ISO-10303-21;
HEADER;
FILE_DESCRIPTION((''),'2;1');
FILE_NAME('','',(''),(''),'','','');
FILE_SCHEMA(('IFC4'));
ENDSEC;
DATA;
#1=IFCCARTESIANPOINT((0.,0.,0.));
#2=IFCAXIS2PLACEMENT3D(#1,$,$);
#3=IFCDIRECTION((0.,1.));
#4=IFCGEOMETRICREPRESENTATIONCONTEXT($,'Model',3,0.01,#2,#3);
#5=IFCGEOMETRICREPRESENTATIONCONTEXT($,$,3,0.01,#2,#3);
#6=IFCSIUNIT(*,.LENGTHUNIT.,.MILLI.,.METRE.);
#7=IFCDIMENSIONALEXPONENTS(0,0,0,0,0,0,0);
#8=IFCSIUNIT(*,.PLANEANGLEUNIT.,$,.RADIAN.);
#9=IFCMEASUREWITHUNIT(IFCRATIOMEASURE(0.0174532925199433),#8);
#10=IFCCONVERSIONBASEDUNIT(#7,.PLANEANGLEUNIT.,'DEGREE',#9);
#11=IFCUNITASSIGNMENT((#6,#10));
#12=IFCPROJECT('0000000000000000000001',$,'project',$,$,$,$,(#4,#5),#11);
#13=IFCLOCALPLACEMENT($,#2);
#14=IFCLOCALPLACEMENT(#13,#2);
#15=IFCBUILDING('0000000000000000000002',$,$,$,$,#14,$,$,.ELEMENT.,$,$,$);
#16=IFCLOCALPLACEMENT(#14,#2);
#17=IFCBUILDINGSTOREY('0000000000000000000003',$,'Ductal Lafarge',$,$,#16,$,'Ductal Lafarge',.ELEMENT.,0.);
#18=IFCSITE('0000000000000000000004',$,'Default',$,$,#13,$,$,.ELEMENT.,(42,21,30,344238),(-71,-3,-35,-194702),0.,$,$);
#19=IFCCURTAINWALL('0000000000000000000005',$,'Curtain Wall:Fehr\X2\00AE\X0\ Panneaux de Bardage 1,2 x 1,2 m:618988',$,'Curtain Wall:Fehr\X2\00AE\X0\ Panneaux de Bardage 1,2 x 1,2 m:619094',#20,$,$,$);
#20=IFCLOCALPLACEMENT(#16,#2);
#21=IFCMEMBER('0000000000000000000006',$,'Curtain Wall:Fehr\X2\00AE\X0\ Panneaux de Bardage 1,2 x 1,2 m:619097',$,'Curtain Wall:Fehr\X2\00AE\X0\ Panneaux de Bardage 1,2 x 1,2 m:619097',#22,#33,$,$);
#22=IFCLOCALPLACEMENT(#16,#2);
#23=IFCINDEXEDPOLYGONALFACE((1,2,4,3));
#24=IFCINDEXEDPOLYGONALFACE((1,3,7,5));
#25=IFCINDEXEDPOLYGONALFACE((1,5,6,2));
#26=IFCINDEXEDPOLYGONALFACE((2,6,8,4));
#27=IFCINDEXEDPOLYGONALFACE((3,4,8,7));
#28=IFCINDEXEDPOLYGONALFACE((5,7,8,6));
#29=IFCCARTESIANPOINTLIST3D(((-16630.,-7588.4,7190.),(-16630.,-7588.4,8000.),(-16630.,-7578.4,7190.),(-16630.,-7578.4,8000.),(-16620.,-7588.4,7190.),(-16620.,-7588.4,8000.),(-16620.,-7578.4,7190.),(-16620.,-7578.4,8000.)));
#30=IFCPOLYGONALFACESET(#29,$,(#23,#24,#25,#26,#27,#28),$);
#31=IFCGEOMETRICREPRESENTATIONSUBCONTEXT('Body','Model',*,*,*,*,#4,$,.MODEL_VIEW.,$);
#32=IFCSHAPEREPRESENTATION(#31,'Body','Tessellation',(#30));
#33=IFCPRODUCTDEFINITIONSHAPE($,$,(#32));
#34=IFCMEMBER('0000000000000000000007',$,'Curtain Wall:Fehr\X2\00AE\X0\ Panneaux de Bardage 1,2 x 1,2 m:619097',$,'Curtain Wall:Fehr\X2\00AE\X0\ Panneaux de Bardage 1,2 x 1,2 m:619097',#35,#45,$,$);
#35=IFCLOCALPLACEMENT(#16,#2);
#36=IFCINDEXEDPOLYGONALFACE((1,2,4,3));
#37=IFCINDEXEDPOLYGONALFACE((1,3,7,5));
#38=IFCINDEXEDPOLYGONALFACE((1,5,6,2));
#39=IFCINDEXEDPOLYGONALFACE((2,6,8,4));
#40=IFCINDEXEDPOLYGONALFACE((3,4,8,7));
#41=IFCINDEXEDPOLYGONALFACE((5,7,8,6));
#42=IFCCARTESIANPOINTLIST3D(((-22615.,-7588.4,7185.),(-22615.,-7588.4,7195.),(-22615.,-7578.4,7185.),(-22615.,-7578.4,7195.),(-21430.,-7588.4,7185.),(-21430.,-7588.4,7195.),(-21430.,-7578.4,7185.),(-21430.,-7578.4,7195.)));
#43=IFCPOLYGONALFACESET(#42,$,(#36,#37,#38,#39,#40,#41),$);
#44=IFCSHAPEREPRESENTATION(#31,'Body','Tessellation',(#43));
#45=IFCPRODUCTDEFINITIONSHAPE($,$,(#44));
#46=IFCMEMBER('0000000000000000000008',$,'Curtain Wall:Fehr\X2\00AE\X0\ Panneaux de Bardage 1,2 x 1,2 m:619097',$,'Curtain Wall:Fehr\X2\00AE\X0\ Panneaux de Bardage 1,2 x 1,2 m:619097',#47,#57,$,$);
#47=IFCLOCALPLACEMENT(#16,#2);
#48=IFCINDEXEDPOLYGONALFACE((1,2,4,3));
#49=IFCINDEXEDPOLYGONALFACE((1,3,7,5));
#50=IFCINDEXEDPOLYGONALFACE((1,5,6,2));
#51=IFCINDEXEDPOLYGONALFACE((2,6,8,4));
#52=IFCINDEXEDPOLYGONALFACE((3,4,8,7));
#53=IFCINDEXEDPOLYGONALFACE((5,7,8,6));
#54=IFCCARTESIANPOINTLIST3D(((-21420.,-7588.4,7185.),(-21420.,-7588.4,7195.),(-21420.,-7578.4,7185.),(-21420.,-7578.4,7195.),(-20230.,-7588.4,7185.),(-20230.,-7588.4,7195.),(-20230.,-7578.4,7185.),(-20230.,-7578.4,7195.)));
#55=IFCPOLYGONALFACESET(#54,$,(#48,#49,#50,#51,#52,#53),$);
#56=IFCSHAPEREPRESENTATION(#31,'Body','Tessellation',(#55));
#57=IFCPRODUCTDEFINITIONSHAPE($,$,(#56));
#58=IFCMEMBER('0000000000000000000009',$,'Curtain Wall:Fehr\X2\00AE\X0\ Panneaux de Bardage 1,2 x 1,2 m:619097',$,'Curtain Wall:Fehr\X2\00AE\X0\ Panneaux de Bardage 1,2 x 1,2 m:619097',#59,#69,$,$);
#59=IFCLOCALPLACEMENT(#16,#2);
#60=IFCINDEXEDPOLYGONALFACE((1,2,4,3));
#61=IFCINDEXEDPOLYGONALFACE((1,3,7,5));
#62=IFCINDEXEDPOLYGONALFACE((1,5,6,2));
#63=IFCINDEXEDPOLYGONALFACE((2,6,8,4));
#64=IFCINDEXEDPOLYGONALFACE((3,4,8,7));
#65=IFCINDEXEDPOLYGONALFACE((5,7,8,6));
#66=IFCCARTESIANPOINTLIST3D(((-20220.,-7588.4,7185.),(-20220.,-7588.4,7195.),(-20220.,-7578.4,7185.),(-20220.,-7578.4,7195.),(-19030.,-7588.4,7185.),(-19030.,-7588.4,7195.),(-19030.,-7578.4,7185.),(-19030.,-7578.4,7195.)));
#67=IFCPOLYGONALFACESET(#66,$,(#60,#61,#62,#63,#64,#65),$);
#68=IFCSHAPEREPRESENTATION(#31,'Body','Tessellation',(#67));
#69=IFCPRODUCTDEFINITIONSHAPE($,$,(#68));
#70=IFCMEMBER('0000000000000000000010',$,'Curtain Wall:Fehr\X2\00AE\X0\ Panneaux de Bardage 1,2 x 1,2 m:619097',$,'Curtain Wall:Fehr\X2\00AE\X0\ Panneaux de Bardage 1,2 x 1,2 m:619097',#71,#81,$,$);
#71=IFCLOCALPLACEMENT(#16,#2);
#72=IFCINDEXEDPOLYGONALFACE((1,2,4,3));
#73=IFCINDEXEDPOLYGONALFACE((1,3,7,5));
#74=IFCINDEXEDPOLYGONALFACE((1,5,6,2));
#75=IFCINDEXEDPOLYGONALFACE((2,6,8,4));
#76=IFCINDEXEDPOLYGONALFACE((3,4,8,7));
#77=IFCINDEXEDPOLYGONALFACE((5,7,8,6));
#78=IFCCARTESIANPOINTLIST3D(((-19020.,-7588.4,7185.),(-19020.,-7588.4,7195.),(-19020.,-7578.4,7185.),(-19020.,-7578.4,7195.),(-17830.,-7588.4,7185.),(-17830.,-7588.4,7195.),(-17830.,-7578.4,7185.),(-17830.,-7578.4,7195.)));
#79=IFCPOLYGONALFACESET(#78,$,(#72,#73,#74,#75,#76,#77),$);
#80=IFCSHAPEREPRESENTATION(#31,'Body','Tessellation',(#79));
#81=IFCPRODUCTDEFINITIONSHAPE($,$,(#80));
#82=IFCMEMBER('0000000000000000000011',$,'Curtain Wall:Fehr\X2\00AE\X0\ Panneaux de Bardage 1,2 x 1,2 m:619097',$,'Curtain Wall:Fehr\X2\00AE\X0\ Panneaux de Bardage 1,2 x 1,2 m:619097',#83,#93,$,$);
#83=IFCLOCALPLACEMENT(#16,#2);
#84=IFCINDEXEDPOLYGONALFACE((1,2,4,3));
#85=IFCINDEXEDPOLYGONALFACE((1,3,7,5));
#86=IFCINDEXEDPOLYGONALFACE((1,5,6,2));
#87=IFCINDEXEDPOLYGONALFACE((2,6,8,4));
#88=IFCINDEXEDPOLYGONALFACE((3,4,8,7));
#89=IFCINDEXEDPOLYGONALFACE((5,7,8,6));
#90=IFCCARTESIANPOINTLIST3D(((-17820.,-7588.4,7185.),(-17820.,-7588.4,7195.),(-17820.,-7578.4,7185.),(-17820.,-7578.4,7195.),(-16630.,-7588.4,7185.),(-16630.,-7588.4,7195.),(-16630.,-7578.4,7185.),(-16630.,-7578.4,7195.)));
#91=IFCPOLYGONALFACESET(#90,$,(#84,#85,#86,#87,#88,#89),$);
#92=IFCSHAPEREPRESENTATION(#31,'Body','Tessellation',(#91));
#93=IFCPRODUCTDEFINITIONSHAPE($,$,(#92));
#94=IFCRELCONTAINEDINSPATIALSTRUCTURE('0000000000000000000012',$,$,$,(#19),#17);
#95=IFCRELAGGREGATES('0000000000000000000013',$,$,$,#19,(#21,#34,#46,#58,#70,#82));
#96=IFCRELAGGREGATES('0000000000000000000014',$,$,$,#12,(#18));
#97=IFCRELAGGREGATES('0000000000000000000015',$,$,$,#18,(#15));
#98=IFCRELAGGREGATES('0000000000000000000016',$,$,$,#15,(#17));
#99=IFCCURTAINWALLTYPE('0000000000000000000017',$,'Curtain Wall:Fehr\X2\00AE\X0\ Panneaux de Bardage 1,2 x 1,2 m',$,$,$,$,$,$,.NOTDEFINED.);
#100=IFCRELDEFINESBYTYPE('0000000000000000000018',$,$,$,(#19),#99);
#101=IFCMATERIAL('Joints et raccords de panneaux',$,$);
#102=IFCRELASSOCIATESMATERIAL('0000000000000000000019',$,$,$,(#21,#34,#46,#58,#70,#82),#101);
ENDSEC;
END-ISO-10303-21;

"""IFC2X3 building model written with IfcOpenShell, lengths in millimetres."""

from ifc_helpers import new_model, entity, si_unit, converted_unit, direction, frame, frame_2d, origin, origin_2d_with_axis, place, context, subcontext, project, spatial, rectangle, extrude, material, type_object, element, aggregate, save


model = new_model("IFC2X3")

# Units and contexts
model_context = context("Model", 3, precision=0.01, world=origin(), true_north=direction((0.0, 1.0)))
context_of_model = context(None, 3, precision=0.01, world=origin(), true_north=direction((0.0, 1.0)))
body_context = subcontext(model_context, "Body", "Model", "MODEL_VIEW")
ifc_project = project(units=[si_unit("LENGTHUNIT", "METRE", prefix="MILLI"), converted_unit("PLANEANGLEUNIT", "DEGREE", entity("IfcRatioMeasure", 0.0174532925199433), si_unit("PLANEANGLEUNIT", "RADIAN"), dimensions=[0, 0, 0, 0, 0, 0, 0])], contexts=[model_context, context_of_model])

# Site, building, storey
site_placement = place(None, origin())
site = spatial("IfcSite", under=ifc_project, at=site_placement, Name="Default", CompositionType="ELEMENT", RefLatitude=(42, 21, 30, 344238), RefLongitude=(-71, -3, -35, -194702), RefElevation=0.0)
building_placement = place(site_placement, origin())
building = spatial("IfcBuilding", under=site, at=building_placement, CompositionType="ELEMENT")
storey_placement = place(building_placement, origin())
storey = spatial("IfcBuildingStorey", under=building, at=storey_placement, Name="Ductal Lafarge", LongName="Ductal Lafarge", CompositionType="ELEMENT", Elevation=0.0)

# Curtain wall, members
curtain_wall_type = type_object("IfcCurtainWallType", Name="Curtain Wall:Fehr® Panneaux de Bardage 1,2 x 1,2 m", PredefinedType="NOTDEFINED")
curtain_wall_placement = place(storey_placement, origin())
curtain_wall = element("IfcCurtainWall", 1, at=curtain_wall_placement, inside=storey, type_object=curtain_wall_type, Name="Curtain Wall:Fehr® Panneaux de Bardage 1,2 x 1,2 m:618988", ObjectType="Curtain Wall:Fehr® Panneaux de Bardage 1,2 x 1,2 m:619094")
ifc_material = material(Name="Joints et raccords de panneaux")
member_1_placement = place(curtain_wall_placement, frame((-16630.0, -7588.4, 7190.0)))
member_1 = element("IfcMember", 2, at=member_1_placement, material=ifc_material, Name="Curtain Wall:Fehr® Panneaux de Bardage 1,2 x 1,2 m:619097", ObjectType="Curtain Wall:Fehr® Panneaux de Bardage 1,2 x 1,2 m:619097", context=body_context, shape_type="SweptSolid", body=[
    extrude(rectangle(XDim=10.0, YDim=10.0, at=frame_2d((0.0, 0.0), x_axis=(1.0, 0.0))), frame((5.0, 5.0, 0.0), z_axis=(0.0, 0.0, 1.0), x_axis=(0.0, 1.0, 0.0)), (0.0, 0.0, 1.0), 810.0),
])
member_2_placement = place(curtain_wall_placement, frame((-22615.0, -7588.4, 7185.0)))
member_2 = element("IfcMember", 3, at=member_2_placement, material=ifc_material, Name="Curtain Wall:Fehr® Panneaux de Bardage 1,2 x 1,2 m:619097", ObjectType="Curtain Wall:Fehr® Panneaux de Bardage 1,2 x 1,2 m:619097", context=body_context, shape_type="SweptSolid", body=[
    extrude(rectangle(XDim=1185.0, YDim=10.0, at=origin_2d_with_axis()), frame((592.5, 5.0, 0.0), z_axis=(0.0, 0.0, 1.0), x_axis=(-1.0, 0.0, 0.0)), (0.0, 0.0, 1.0), 10.0),
])
member_3_placement = place(curtain_wall_placement, frame((-21420.0, -7588.4, 7185.0)))
member_3 = element("IfcMember", 4, at=member_3_placement, material=ifc_material, Name="Curtain Wall:Fehr® Panneaux de Bardage 1,2 x 1,2 m:619097", ObjectType="Curtain Wall:Fehr® Panneaux de Bardage 1,2 x 1,2 m:619097", context=body_context, shape_type="SweptSolid", body=[
    extrude(rectangle(XDim=1190.0, YDim=10.0, at=frame_2d((0.0, 0.0), x_axis=(1.0, 0.0))), frame((595.0, 5.0, 0.0), z_axis=(0.0, 0.0, 1.0), x_axis=(-1.0, 0.0, 0.0)), (0.0, 0.0, 1.0), 10.0),
])
member_4_placement = place(curtain_wall_placement, frame((-20220.0, -7588.4, 7185.0)))
member_4 = element("IfcMember", 5, at=member_4_placement, material=ifc_material, Name="Curtain Wall:Fehr® Panneaux de Bardage 1,2 x 1,2 m:619097", ObjectType="Curtain Wall:Fehr® Panneaux de Bardage 1,2 x 1,2 m:619097", context=body_context, shape_type="SweptSolid", body=[
    extrude(rectangle(XDim=1190.0, YDim=10.0, at=frame_2d((0.0, 0.0), x_axis=(1.0, 0.0))), frame((595.0, 5.0, 0.0), z_axis=(0.0, 0.0, 1.0), x_axis=(-1.0, 0.0, 0.0)), (0.0, 0.0, 1.0), 10.0),
])
member_5_placement = place(curtain_wall_placement, frame((-19020.0, -7588.4, 7185.0)))
member_5 = element("IfcMember", 6, at=member_5_placement, material=ifc_material, Name="Curtain Wall:Fehr® Panneaux de Bardage 1,2 x 1,2 m:619097", ObjectType="Curtain Wall:Fehr® Panneaux de Bardage 1,2 x 1,2 m:619097", context=body_context, shape_type="SweptSolid", body=[
    extrude(rectangle(XDim=1190.0, YDim=10.0, at=frame_2d((0.0, 0.0), x_axis=(1.0, 0.0))), frame((595.0, 5.0, 0.0), z_axis=(0.0, 0.0, 1.0), x_axis=(-1.0, 0.0, 0.0)), (0.0, 0.0, 1.0), 10.0),
])
member_6_placement = place(curtain_wall_placement, frame((-17820.0, -7588.4, 7185.0)))
member_6 = element("IfcMember", 7, at=member_6_placement, material=ifc_material, Name="Curtain Wall:Fehr® Panneaux de Bardage 1,2 x 1,2 m:619097", ObjectType="Curtain Wall:Fehr® Panneaux de Bardage 1,2 x 1,2 m:619097", context=body_context, shape_type="SweptSolid", body=[
    extrude(rectangle(XDim=1190.0, YDim=10.0, at=frame_2d((0.0, 0.0), x_axis=(1.0, 0.0))), frame((595.0, 5.0, 0.0), z_axis=(0.0, 0.0, 1.0), x_axis=(-1.0, 0.0, 0.0)), (0.0, 0.0, 1.0), 10.0),
])
aggregate(curtain_wall, [member_1, member_2, member_3, member_4, member_5, member_6])

save(model, "model.ifc")
